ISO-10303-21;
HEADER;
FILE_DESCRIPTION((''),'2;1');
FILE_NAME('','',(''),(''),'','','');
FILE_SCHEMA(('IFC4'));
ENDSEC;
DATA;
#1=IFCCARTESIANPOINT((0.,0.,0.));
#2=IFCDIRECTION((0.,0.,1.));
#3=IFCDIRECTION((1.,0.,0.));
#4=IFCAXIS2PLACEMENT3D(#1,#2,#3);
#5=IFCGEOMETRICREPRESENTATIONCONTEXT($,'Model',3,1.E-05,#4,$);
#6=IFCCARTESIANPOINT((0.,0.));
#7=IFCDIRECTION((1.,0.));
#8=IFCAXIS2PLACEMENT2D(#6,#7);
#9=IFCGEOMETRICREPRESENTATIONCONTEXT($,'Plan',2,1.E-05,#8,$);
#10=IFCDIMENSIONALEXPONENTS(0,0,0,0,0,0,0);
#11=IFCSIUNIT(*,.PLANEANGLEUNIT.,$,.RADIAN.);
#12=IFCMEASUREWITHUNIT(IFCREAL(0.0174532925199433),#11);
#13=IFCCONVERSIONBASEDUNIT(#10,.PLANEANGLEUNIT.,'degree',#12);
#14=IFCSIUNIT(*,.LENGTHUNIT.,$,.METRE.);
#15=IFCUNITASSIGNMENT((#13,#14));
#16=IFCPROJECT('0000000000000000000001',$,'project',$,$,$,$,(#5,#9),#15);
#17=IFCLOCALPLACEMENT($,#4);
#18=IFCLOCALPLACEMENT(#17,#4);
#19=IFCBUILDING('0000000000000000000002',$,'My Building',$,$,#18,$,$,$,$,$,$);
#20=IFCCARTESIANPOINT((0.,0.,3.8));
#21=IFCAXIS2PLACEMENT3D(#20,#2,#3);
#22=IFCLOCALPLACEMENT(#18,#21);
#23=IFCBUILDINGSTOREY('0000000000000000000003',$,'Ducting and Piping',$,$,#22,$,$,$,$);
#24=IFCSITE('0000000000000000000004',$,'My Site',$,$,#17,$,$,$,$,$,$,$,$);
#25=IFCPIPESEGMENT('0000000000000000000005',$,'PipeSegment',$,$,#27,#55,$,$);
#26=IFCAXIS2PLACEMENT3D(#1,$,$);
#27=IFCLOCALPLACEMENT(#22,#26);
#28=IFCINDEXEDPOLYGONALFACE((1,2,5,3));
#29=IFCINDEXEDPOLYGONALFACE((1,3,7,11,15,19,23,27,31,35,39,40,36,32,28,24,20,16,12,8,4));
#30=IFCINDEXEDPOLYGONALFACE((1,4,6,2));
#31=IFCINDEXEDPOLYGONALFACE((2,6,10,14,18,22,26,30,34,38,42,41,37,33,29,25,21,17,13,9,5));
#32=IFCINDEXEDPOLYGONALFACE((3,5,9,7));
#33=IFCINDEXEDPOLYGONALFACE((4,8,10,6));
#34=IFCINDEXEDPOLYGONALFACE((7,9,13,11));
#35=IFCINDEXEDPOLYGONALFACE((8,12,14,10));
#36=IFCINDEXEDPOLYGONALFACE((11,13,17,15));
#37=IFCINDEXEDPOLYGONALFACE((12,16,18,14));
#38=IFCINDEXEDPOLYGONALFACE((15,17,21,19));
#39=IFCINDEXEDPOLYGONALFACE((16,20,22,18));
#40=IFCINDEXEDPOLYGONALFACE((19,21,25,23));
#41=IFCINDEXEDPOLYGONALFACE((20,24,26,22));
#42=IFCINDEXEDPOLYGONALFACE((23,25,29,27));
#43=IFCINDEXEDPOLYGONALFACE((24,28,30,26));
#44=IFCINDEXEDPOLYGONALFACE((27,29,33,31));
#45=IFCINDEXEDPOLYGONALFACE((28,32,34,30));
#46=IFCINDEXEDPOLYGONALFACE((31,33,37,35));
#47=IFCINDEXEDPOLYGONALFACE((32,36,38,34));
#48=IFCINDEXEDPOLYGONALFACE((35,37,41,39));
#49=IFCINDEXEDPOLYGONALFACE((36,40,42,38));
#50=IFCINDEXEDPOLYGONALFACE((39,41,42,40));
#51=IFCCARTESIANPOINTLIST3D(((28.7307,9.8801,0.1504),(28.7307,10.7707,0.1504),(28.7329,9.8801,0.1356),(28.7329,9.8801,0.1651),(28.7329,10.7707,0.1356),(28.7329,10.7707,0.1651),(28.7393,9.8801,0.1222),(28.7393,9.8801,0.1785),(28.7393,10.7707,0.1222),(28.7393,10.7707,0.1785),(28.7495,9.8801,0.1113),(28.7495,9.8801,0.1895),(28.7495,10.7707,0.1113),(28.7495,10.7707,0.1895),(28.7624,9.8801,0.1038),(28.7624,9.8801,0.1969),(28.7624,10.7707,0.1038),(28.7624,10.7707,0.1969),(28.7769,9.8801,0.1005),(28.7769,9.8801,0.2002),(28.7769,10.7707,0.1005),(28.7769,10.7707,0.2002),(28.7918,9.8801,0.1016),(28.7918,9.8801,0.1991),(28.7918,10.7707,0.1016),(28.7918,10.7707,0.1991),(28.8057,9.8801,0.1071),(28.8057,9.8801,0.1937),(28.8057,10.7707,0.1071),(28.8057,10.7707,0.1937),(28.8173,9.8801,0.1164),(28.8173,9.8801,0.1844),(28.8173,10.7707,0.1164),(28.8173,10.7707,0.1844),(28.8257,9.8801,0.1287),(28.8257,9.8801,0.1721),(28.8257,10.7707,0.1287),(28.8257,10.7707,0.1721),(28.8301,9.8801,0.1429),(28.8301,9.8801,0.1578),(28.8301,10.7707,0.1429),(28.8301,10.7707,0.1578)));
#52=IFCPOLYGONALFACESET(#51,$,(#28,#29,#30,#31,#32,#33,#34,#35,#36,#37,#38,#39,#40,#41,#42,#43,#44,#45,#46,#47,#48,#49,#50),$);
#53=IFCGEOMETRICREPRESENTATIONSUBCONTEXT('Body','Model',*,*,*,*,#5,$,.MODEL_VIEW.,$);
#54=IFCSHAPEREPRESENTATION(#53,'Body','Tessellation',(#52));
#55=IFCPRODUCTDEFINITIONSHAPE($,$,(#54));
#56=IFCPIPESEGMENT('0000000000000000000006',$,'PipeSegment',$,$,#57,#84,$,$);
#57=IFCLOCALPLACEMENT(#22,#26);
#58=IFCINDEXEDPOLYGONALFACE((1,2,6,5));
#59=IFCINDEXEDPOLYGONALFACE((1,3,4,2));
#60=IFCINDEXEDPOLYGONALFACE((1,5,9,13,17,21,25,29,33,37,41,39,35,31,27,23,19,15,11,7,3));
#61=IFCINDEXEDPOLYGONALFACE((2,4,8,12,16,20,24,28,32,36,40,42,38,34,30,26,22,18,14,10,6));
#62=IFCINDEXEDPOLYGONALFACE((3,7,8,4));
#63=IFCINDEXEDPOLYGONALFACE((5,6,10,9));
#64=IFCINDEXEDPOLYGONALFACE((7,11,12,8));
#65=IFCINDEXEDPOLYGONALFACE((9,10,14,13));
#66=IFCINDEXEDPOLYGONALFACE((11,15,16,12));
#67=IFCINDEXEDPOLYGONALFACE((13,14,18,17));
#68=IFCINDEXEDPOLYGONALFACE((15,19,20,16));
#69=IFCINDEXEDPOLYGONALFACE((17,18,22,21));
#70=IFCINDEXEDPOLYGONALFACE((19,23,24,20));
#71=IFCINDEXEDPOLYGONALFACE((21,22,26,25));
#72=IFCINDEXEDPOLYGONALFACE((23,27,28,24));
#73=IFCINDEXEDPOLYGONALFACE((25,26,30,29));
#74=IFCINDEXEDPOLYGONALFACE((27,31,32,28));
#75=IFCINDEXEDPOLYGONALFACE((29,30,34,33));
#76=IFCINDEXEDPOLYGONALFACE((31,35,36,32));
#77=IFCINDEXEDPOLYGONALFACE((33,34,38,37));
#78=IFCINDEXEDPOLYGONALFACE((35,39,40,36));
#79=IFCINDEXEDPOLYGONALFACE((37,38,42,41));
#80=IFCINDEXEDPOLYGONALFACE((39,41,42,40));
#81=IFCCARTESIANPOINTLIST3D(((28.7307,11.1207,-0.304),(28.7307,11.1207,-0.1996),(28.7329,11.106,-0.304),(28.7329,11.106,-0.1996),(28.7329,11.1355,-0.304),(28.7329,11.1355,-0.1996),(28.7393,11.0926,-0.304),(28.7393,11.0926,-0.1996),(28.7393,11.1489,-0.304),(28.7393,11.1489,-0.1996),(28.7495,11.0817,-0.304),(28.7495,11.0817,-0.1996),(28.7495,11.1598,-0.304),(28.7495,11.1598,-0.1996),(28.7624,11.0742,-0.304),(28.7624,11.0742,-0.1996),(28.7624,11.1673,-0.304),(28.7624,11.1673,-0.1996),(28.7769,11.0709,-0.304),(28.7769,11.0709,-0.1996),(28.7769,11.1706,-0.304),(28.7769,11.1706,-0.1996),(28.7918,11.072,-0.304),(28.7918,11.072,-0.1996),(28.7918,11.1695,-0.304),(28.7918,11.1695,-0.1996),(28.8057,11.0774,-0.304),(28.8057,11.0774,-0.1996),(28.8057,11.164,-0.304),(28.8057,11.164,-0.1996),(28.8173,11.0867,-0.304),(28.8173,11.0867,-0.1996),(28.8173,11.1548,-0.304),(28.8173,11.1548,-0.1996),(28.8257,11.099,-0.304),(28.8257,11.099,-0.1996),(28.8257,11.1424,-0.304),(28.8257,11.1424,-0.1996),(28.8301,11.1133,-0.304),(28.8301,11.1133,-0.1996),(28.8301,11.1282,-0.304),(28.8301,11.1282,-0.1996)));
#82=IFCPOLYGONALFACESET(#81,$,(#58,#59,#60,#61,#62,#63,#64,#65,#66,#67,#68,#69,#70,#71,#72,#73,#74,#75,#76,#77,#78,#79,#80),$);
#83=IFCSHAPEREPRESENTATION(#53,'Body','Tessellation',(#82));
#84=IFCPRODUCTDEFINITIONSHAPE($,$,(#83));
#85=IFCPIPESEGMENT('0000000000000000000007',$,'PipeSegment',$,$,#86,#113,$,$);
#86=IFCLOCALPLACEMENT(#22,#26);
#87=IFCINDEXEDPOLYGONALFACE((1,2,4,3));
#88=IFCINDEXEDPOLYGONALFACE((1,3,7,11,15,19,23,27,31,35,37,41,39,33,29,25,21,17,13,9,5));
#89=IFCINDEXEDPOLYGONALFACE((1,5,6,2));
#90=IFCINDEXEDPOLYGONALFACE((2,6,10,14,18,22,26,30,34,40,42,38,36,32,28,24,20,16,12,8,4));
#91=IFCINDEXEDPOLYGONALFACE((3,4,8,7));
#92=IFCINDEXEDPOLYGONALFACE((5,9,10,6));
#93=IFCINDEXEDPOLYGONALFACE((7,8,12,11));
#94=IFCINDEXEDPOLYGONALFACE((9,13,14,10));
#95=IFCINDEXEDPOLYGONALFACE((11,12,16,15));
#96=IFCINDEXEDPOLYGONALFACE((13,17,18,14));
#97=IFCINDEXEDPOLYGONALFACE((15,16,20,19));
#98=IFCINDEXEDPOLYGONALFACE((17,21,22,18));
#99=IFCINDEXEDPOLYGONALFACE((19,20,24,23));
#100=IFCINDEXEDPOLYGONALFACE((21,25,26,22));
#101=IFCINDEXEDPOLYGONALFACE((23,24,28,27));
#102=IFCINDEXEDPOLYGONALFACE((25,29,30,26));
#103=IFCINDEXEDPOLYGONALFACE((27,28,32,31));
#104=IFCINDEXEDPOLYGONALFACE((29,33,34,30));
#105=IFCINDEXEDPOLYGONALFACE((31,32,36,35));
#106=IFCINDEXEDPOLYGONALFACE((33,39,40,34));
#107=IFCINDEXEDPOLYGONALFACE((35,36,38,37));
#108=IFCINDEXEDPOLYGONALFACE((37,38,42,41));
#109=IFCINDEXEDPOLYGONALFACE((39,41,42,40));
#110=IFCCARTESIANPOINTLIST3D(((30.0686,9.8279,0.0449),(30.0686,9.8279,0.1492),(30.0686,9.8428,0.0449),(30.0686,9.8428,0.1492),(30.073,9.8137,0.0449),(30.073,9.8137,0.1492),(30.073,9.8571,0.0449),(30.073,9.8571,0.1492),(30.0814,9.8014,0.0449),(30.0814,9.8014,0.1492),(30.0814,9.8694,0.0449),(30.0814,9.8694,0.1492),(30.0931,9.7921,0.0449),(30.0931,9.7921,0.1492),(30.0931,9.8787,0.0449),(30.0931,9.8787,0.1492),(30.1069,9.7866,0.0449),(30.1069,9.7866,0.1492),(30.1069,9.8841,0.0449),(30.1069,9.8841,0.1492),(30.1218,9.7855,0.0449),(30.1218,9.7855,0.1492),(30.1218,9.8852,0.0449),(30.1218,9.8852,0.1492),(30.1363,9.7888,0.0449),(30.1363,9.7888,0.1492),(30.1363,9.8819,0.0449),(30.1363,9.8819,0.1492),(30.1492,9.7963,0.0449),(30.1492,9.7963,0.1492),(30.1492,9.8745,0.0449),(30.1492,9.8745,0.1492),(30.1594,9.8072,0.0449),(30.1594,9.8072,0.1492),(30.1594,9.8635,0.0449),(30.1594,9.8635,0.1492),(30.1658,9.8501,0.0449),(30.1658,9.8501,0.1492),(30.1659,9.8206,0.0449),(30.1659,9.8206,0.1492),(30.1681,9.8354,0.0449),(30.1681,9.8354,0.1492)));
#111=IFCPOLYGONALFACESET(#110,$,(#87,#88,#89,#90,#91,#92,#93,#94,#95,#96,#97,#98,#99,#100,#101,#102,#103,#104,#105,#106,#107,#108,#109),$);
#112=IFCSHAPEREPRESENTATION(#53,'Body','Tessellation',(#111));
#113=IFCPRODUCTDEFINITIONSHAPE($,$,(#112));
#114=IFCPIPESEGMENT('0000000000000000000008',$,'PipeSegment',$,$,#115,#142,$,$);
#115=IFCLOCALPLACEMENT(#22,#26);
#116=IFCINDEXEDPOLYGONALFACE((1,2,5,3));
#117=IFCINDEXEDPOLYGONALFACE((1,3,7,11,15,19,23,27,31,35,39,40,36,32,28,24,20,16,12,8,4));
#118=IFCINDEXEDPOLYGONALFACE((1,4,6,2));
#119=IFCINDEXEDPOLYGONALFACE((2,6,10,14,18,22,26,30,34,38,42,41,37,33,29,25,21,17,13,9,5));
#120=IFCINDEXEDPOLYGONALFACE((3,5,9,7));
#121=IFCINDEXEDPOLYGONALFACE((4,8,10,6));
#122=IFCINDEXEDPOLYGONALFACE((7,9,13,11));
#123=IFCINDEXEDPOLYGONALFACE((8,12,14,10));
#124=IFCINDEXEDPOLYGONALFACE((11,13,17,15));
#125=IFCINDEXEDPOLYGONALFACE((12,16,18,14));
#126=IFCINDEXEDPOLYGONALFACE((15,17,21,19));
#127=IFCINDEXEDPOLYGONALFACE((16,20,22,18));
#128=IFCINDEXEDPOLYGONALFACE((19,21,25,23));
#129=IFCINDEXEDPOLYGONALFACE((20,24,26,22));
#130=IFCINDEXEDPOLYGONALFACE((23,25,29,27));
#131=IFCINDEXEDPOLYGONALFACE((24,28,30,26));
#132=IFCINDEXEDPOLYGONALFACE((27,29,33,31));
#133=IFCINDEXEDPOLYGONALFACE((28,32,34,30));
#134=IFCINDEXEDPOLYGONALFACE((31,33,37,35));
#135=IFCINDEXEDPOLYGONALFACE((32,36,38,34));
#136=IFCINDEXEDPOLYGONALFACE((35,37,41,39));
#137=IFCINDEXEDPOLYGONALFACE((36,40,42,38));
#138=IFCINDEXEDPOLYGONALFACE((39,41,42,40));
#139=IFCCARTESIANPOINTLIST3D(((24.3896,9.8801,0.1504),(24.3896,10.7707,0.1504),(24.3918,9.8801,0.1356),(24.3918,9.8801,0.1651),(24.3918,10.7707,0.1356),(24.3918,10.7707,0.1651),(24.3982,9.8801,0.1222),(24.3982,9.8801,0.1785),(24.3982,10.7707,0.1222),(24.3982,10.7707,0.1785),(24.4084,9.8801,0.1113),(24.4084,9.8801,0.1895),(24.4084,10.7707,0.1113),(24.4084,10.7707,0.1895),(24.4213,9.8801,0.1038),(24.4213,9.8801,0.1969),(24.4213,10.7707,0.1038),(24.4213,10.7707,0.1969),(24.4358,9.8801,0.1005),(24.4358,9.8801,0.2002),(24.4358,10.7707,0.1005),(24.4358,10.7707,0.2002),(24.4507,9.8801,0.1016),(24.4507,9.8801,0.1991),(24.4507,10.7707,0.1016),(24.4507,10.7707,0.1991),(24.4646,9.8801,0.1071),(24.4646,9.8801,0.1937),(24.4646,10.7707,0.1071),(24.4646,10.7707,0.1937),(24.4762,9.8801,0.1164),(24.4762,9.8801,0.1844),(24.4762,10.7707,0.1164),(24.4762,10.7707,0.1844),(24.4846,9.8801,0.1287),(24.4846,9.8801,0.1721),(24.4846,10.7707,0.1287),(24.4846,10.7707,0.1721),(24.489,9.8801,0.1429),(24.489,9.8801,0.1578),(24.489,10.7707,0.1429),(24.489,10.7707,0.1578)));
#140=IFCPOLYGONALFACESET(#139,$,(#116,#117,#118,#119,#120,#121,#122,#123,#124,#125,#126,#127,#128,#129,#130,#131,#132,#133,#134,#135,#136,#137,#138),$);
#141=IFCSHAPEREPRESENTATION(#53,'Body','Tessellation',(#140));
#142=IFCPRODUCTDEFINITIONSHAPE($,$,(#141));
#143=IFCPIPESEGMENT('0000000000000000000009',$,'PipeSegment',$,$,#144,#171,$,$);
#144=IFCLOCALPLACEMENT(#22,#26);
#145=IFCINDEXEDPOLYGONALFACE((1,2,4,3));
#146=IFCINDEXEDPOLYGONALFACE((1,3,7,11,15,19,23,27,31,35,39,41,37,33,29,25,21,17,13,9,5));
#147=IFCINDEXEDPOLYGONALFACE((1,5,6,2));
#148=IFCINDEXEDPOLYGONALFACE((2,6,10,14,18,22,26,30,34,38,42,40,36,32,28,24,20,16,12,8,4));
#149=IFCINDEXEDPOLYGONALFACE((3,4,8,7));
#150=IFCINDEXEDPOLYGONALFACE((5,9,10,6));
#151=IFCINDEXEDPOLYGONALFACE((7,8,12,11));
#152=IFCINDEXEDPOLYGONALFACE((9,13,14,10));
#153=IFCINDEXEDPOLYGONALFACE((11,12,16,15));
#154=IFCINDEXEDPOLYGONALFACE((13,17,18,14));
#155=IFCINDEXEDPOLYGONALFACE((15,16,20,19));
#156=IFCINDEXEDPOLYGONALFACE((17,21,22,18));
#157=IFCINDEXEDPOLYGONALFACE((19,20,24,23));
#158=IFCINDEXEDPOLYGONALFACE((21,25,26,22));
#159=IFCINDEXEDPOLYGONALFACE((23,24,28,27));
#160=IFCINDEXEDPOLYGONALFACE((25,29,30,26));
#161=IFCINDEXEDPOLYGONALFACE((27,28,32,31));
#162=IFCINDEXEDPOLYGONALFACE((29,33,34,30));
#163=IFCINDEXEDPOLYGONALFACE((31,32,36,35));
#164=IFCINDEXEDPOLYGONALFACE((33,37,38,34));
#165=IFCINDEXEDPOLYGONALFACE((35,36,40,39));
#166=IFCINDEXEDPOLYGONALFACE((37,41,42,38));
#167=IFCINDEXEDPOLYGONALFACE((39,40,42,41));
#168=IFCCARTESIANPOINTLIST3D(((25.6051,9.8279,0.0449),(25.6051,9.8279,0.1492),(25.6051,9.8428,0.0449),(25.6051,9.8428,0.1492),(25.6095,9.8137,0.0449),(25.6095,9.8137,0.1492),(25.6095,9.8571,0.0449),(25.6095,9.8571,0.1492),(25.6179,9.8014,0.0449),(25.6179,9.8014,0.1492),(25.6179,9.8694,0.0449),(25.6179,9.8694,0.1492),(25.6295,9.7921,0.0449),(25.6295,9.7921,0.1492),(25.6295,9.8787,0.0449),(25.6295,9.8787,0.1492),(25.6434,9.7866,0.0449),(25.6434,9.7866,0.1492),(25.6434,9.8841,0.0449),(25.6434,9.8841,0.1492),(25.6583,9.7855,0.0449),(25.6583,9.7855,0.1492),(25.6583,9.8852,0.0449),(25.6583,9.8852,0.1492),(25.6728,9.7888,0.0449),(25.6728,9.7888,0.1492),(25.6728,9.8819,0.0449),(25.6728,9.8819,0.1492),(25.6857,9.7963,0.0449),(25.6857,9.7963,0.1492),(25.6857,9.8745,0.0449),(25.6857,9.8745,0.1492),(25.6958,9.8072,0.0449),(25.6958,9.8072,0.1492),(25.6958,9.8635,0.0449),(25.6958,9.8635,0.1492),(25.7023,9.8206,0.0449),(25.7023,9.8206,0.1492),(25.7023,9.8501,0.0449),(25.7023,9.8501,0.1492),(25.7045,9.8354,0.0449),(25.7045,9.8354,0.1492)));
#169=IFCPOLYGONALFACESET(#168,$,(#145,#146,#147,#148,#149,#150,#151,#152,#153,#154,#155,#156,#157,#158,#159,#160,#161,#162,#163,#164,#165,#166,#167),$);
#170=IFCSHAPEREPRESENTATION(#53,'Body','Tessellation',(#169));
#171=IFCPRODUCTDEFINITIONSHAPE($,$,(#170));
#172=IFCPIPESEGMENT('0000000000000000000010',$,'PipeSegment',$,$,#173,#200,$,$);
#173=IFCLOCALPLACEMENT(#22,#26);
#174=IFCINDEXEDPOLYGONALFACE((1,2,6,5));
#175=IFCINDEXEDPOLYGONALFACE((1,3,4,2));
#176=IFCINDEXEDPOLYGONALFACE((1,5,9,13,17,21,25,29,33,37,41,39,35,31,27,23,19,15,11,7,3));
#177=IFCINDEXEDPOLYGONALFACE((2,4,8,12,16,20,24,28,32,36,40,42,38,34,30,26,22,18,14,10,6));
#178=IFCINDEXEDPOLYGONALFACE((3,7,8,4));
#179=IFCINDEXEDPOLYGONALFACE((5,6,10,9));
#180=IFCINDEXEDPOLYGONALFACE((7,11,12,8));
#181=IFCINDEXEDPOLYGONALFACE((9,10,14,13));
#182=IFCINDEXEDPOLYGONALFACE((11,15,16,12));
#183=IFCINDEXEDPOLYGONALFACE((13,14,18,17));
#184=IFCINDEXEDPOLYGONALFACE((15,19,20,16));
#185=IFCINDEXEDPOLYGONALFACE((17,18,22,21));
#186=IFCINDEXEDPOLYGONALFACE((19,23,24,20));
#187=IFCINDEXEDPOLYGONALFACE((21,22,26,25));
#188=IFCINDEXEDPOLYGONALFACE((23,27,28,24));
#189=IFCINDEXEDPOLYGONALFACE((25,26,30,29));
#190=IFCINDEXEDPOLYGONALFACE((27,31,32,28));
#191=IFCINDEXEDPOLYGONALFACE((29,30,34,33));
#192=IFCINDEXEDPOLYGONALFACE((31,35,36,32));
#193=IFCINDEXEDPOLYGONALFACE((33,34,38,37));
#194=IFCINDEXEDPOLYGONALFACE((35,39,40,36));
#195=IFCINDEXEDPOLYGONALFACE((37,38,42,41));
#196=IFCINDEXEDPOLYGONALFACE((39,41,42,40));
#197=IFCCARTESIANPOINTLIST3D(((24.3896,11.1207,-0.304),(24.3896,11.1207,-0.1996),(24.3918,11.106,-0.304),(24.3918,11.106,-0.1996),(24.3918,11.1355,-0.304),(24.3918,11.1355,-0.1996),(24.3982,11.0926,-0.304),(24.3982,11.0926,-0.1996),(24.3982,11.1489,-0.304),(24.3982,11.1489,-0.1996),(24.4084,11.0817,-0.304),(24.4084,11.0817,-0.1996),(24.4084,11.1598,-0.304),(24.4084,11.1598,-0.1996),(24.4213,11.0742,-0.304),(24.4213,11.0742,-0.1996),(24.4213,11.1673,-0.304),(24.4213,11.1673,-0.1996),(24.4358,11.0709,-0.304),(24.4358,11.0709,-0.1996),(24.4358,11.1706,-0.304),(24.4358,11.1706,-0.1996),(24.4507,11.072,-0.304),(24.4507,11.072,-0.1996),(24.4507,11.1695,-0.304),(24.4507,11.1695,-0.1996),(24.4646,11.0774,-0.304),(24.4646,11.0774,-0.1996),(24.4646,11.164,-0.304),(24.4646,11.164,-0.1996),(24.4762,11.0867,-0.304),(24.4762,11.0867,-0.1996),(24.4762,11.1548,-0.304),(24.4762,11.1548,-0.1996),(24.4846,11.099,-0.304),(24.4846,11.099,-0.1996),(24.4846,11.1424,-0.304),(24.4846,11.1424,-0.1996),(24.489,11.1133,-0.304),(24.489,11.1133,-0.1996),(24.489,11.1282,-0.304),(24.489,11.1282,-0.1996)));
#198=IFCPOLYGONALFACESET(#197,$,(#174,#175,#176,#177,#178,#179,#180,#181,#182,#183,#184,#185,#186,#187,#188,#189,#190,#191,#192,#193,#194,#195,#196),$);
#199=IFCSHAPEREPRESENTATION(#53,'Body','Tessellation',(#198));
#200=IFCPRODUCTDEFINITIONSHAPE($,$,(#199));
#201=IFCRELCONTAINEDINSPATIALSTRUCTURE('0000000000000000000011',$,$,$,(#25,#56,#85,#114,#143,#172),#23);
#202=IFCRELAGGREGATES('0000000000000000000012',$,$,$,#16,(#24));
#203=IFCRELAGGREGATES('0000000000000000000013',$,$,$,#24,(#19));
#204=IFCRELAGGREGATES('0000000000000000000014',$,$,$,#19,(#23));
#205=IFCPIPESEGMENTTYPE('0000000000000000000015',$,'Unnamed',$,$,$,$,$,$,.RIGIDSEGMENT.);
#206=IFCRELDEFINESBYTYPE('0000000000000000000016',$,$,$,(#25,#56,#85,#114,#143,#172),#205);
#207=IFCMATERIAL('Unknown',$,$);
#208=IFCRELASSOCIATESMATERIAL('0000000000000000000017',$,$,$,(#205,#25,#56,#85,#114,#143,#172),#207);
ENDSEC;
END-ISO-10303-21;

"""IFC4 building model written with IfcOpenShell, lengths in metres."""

from ifc_helpers import new_model, entity, si_unit, converted_unit, frame, origin_with_axes, origin_2d_with_axis, place, context, subcontext, project, spatial, circle, extrude, material, material_profile, profile_set, profile_usage, type_object, element, save


model = new_model("IFC4")

# Units and contexts
model_context = context("Model", 3, precision=1e-05, world=origin_with_axes())
plan_context = context("Plan", 2, precision=1e-05, world=origin_2d_with_axis())
body_context = subcontext(model_context, "Body", "Model", "MODEL_VIEW")
ifc_project = project(units=[converted_unit("PLANEANGLEUNIT", "degree", entity("IfcReal", 0.0174532925199433), si_unit("PLANEANGLEUNIT", "RADIAN"), dimensions=[0, 0, 0, 0, 0, 0, 0]), si_unit("LENGTHUNIT", "METRE")], contexts=[model_context, plan_context])

# Site, building, storey
site_placement = place(None, origin_with_axes())
site = spatial("IfcSite", under=ifc_project, at=site_placement, Name="My Site")
building_placement = place(site_placement, origin_with_axes())
building = spatial("IfcBuilding", under=site, at=building_placement, Name="My Building")
storey_placement = place(building_placement, frame((0.0, 0.0, 3.8), z_axis=(0.0, 0.0, 1.0), x_axis=(1.0, 0.0, 0.0)))
storey = spatial("IfcBuildingStorey", under=building, at=storey_placement, Name="Ducting and Piping")

# Pipe segments
ifc_material = material(Name="Unknown")
ifc_material_profile_1 = material_profile(ifc_material, circle(Radius=0.05))
ifc_profile_set_1 = profile_set([ifc_material_profile_1])
ifc_profile_usage_1 = profile_usage(ifc_profile_set_1, cardinal=5)
pipe_segment_type = type_object("IfcPipeSegmentType", Name="Unnamed", PredefinedType="RIGIDSEGMENT", material=ifc_profile_set_1)
pipe_segment_1_placement = place(storey_placement, frame((28.7807, 9.8801, 0.1504), z_axis=(0.0, 1.0, 0.0), x_axis=(-1.0, 0.0, 0.0)))
element("IfcPipeSegment", 1, at=pipe_segment_1_placement, inside=storey, type_object=pipe_segment_type, material=ifc_profile_usage_1, Name="PipeSegment", context=body_context, shape_type="SweptSolid", body=[
    extrude(circle(Radius=0.05), origin_with_axes(), (0.0, 0.0, 1.0), 0.8907),
])
ifc_profile_usage_2 = profile_usage(ifc_profile_set_1, cardinal=5)
pipe_segment_2_placement = place(storey_placement, frame((28.7807, 11.1207, -0.304), z_axis=(0.0, 0.0, 1.0), x_axis=(-1.0, 0.0, 0.0)))
element("IfcPipeSegment", 2, at=pipe_segment_2_placement, inside=storey, type_object=pipe_segment_type, material=ifc_profile_usage_2, Name="PipeSegment", context=body_context, shape_type="SweptSolid", body=[
    extrude(circle(Radius=0.05), origin_with_axes(), (0.0, 0.0, 1.0), 0.1043),
])
ifc_profile_usage_3 = profile_usage(ifc_profile_set_1, cardinal=5)
pipe_segment_3_placement = place(storey_placement, frame((30.1181, 9.8354, 0.0449), z_axis=(0.0, 0.0, 1.0), x_axis=(1.0, 0.00006, 0.0)))
element("IfcPipeSegment", 3, at=pipe_segment_3_placement, inside=storey, type_object=pipe_segment_type, material=ifc_profile_usage_3, Name="PipeSegment", context=body_context, shape_type="SweptSolid", body=[
    extrude(circle(Radius=0.05), origin_with_axes(), (0.0, 0.0, 1.0), 0.1043),
])
ifc_profile_usage_4 = profile_usage(ifc_profile_set_1, cardinal=5)
pipe_segment_4_placement = place(storey_placement, frame((24.4396, 9.8801, 0.1504), z_axis=(0.0, 1.0, 0.0), x_axis=(-1.0, 0.0, 0.0)))
element("IfcPipeSegment", 4, at=pipe_segment_4_placement, inside=storey, type_object=pipe_segment_type, material=ifc_profile_usage_4, Name="PipeSegment", context=body_context, shape_type="SweptSolid", body=[
    extrude(circle(Radius=0.05), origin_with_axes(), (0.0, 0.0, 1.0), 0.8907),
])
ifc_profile_usage_5 = profile_usage(ifc_profile_set_1, cardinal=5)
pipe_segment_5_placement = place(storey_placement, frame((25.6545, 9.8354, 0.0449), z_axis=(0.0, 0.0, 1.0), x_axis=(1.0, 0.00006, 0.0)))
element("IfcPipeSegment", 5, at=pipe_segment_5_placement, inside=storey, type_object=pipe_segment_type, material=ifc_profile_usage_5, Name="PipeSegment", context=body_context, shape_type="SweptSolid", body=[
    extrude(circle(Radius=0.05), origin_with_axes(), (0.0, 0.0, 1.0), 0.1043),
])
ifc_profile_usage_6 = profile_usage(ifc_profile_set_1, cardinal=5)
pipe_segment_6_placement = place(storey_placement, frame((24.4396, 11.1207, -0.304), z_axis=(0.0, 0.0, 1.0), x_axis=(-1.0, 0.0, 0.0)))
element("IfcPipeSegment", 6, at=pipe_segment_6_placement, inside=storey, type_object=pipe_segment_type, material=ifc_profile_usage_6, Name="PipeSegment", context=body_context, shape_type="SweptSolid", body=[
    extrude(circle(Radius=0.05), origin_with_axes(), (0.0, 0.0, 1.0), 0.1043),
])

save(model, "model.ifc")
